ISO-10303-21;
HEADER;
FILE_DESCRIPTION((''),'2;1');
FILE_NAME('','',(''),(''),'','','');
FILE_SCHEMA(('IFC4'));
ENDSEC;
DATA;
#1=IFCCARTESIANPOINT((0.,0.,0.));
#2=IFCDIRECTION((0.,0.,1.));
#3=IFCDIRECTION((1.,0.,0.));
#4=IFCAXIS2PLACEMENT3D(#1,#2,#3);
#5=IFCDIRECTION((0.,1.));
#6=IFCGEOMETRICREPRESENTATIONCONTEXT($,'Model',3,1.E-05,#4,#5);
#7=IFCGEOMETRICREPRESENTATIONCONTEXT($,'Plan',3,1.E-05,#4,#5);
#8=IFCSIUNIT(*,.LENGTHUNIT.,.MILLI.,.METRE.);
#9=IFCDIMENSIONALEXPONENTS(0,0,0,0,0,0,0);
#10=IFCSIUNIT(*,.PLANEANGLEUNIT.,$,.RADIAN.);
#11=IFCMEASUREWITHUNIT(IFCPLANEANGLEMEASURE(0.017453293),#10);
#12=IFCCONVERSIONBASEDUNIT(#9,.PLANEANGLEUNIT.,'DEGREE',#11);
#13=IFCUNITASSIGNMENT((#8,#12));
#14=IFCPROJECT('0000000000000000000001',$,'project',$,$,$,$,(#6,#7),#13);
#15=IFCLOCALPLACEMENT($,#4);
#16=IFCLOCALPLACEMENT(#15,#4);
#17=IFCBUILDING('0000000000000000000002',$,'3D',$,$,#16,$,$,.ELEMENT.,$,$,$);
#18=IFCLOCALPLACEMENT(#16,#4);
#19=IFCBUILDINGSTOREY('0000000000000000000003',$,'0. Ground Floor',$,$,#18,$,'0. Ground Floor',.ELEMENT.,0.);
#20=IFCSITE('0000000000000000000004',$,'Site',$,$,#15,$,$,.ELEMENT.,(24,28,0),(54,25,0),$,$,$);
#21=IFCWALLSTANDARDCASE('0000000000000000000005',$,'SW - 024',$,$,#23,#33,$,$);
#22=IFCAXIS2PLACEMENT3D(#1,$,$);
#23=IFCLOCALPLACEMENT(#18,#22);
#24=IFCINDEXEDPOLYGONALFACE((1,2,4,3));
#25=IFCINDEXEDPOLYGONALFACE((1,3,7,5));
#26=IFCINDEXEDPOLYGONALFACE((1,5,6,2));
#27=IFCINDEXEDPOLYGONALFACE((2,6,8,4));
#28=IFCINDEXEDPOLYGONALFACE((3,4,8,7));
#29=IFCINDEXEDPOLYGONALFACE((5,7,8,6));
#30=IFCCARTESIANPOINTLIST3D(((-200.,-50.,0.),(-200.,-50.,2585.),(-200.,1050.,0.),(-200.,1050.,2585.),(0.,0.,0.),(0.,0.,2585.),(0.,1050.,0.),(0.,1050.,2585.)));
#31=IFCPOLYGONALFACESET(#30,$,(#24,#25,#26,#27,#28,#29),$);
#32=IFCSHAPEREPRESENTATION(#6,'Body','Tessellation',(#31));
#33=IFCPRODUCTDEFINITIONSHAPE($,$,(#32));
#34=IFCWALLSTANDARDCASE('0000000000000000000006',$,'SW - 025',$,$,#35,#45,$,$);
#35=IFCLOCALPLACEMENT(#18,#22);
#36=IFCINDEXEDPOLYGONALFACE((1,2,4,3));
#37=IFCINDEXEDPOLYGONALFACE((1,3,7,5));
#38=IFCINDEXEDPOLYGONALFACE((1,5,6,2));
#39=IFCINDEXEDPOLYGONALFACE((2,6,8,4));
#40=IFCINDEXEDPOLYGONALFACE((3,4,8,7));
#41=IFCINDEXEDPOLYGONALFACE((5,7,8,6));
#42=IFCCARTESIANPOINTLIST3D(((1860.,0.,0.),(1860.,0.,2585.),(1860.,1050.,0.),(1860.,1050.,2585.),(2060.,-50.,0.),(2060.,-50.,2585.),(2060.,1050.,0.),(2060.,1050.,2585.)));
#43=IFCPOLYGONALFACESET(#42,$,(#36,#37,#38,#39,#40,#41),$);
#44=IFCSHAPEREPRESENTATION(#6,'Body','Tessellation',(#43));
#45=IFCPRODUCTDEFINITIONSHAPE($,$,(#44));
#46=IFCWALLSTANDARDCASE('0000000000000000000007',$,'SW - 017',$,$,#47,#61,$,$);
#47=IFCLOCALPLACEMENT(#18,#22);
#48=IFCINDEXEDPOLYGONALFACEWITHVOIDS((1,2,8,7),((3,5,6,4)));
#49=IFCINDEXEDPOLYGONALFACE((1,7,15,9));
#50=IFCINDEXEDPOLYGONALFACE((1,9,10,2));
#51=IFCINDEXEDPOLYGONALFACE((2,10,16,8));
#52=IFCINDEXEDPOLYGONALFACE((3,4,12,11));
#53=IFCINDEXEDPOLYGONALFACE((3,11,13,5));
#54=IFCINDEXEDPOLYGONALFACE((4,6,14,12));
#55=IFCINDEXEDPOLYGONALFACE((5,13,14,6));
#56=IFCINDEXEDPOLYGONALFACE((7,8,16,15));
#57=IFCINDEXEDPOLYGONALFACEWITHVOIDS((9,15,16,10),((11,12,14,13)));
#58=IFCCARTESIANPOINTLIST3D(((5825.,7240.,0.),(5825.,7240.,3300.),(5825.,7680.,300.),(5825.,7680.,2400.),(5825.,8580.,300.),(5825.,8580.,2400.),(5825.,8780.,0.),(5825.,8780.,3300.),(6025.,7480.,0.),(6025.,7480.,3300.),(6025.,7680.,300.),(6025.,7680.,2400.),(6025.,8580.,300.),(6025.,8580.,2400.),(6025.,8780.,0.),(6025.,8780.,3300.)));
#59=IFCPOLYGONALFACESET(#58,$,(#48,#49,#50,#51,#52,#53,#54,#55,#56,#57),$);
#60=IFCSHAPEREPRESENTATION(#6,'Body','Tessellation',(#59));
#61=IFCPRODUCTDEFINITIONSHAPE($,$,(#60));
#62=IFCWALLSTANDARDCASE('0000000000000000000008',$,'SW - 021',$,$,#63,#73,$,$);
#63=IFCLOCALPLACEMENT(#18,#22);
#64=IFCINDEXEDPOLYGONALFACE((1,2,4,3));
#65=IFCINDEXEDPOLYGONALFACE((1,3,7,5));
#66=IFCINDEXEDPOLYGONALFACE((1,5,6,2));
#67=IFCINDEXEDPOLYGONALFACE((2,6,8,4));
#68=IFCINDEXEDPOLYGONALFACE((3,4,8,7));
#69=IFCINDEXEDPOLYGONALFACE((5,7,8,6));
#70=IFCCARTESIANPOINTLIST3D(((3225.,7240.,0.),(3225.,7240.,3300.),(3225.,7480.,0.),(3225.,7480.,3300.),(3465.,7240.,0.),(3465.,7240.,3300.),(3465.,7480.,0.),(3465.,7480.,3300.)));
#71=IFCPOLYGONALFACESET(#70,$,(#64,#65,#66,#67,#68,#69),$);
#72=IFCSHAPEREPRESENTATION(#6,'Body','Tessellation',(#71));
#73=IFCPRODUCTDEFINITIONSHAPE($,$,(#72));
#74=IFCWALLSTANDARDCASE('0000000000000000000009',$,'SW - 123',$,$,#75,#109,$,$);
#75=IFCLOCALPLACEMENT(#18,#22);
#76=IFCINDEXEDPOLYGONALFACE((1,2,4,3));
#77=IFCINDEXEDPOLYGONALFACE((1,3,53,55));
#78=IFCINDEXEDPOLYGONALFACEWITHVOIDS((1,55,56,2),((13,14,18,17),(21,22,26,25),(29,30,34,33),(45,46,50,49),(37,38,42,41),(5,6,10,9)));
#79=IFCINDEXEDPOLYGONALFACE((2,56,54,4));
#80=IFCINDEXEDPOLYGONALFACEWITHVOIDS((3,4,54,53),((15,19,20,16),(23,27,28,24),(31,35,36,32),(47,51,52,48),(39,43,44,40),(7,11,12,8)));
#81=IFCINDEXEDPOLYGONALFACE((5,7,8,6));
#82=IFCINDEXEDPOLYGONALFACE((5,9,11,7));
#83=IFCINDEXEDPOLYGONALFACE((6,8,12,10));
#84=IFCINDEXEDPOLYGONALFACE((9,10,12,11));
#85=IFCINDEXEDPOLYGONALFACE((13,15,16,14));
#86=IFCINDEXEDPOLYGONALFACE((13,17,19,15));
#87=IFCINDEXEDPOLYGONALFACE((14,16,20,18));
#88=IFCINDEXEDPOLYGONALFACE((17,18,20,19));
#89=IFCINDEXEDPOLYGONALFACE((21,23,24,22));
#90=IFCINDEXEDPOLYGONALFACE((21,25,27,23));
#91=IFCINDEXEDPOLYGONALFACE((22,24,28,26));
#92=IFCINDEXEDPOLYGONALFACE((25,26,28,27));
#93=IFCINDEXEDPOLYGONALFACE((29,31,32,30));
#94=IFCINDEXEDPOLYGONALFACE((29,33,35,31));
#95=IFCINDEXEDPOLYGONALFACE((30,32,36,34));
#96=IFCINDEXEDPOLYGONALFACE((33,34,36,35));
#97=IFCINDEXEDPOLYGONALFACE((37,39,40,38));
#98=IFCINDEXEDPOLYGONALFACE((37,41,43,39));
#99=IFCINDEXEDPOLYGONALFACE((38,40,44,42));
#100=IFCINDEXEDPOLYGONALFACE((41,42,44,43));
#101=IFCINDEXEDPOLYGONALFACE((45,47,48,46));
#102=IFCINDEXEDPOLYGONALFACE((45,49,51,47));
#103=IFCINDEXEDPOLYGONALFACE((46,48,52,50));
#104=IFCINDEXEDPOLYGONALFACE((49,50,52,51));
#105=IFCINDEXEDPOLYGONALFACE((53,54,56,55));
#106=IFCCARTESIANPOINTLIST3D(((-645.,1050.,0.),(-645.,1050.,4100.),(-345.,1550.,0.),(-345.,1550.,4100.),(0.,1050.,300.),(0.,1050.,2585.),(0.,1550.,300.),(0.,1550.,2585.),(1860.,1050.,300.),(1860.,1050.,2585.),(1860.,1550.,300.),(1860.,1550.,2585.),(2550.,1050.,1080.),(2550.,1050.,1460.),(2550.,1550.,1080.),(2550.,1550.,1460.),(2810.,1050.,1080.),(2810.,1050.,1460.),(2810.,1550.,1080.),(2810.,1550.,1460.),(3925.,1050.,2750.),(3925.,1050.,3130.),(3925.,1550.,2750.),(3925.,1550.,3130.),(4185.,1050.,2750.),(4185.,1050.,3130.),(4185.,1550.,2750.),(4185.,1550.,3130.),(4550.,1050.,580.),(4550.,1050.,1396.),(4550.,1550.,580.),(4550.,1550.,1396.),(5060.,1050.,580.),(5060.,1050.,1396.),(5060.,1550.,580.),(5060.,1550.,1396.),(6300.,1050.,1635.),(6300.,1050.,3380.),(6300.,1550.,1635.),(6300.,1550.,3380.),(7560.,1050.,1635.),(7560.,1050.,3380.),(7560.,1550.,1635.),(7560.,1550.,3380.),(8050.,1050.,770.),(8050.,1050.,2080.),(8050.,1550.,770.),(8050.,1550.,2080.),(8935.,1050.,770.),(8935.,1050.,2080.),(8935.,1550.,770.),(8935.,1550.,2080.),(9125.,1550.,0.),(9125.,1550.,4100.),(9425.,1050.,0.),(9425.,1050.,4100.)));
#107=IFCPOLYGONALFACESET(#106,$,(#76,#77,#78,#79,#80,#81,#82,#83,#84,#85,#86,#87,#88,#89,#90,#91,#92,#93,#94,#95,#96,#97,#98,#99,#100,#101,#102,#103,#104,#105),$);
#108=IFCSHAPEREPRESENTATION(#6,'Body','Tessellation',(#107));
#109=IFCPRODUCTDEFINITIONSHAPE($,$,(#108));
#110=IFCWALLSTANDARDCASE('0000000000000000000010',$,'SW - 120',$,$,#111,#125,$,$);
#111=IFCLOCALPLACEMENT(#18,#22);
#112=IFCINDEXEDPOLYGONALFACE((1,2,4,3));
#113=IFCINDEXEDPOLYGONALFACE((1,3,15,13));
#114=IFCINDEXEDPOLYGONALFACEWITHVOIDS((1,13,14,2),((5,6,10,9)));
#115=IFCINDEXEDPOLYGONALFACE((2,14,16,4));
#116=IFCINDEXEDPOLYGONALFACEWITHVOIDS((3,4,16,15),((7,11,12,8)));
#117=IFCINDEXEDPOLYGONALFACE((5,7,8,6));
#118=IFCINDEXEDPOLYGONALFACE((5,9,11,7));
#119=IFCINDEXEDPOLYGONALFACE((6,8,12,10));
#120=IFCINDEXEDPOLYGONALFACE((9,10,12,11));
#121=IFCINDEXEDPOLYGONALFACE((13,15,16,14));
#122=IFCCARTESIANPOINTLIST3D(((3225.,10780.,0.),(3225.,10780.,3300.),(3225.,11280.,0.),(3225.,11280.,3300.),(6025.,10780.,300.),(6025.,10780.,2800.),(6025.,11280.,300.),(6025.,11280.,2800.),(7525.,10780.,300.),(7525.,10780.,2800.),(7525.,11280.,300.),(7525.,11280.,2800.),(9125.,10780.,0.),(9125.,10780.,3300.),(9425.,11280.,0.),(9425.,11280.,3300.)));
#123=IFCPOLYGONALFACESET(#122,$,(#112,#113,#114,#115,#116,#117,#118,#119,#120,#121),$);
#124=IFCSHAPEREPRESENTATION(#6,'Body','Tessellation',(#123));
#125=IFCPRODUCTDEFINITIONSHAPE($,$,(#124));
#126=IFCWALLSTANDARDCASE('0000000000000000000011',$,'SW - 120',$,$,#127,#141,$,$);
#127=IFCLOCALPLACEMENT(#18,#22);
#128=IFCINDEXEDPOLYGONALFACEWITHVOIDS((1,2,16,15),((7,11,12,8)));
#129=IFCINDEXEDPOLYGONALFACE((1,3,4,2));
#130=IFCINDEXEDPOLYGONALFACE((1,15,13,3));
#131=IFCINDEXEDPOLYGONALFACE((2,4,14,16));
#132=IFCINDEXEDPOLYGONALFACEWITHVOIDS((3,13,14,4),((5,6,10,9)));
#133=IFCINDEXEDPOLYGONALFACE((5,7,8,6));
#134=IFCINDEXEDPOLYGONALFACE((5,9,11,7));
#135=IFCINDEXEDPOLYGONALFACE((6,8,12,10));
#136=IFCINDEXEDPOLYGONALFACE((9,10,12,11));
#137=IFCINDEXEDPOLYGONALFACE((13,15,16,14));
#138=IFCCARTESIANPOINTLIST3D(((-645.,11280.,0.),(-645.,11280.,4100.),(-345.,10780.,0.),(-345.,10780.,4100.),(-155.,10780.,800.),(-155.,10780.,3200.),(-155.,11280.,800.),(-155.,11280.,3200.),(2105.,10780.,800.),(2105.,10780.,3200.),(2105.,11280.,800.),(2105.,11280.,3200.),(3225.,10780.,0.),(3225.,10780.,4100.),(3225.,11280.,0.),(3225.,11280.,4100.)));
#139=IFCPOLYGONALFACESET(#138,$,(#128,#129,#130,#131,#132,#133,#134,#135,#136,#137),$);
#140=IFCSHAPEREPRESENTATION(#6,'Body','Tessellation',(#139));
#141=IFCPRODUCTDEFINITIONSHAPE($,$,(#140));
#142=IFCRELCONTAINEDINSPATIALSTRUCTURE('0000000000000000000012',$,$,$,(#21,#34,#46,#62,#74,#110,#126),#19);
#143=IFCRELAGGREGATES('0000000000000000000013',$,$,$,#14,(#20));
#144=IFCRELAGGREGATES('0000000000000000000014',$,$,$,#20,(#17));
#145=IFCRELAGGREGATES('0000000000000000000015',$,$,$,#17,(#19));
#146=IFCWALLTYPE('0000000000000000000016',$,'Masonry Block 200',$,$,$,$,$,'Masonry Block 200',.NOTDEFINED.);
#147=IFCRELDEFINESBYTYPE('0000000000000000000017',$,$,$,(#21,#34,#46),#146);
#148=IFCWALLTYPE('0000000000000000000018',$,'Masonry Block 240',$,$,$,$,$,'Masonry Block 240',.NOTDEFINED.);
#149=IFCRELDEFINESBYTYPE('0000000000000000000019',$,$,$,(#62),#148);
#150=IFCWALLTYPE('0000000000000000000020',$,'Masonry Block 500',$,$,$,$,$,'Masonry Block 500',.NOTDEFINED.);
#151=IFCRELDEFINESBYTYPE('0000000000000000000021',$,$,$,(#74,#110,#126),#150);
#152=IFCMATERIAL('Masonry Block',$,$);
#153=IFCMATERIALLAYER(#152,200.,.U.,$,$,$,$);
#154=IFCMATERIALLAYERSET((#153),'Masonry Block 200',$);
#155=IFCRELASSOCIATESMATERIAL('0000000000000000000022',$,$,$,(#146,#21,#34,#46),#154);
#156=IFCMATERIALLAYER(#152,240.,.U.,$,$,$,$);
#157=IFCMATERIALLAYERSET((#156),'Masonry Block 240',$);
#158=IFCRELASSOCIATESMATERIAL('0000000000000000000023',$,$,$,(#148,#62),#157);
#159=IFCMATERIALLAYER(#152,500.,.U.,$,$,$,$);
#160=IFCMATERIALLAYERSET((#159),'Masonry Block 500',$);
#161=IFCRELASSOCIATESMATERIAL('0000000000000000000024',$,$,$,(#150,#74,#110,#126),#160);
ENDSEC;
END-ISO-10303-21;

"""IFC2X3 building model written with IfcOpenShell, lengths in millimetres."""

from ifc_helpers import new_model, entity, si_unit, converted_unit, direction, frame, frame_2d, origin_with_axes, place, context, project, spatial, polyline, rectangle, outline, extrude, material, layer, layer_set, layer_usage, type_object, element, save


model = new_model("IFC2X3")

# Units and contexts
model_context = context("Model", 3, precision=1e-05, world=origin_with_axes(), true_north=direction((0.0, 1.0)))
plan_context = context("Plan", 3, precision=1e-05, world=origin_with_axes(), true_north=direction((0.0, 1.0)))
ifc_project = project(units=[si_unit("LENGTHUNIT", "METRE", prefix="MILLI"), converted_unit("PLANEANGLEUNIT", "DEGREE", entity("IfcPlaneAngleMeasure", 0.017453293), si_unit("PLANEANGLEUNIT", "RADIAN"), dimensions=[0, 0, 0, 0, 0, 0, 0])], contexts=[model_context, plan_context])

# Site, building, storey
site_placement = place(None, origin_with_axes())
site = spatial("IfcSite", under=ifc_project, at=site_placement, Name="Site", CompositionType="ELEMENT", RefLatitude=(24, 28, 0), RefLongitude=(54, 25, 0))
building_placement = place(site_placement, origin_with_axes())
building = spatial("IfcBuilding", under=site, at=building_placement, Name="3D", CompositionType="ELEMENT")
storey_placement = place(building_placement, origin_with_axes())
storey = spatial("IfcBuildingStorey", under=building, at=storey_placement, Name="0. Ground Floor", LongName="0. Ground Floor", CompositionType="ELEMENT", Elevation=0.0)

# Shared definitions
ifc_material_1 = material(Name="Masonry Block")
ifc_layer_1 = layer(ifc_material_1, 200.0, ventilated="UNKNOWN")
ifc_layer_set_1 = layer_set([ifc_layer_1], Name="Masonry Block 200")

# Wall
ifc_layer_usage_1 = layer_usage(ifc_layer_set_1, "AXIS2", "NEGATIVE", 0.0)
wall_type_1 = type_object("IfcWallType", Name="Masonry Block 200", ElementType="Masonry Block 200", PredefinedType="NOTDEFINED", material=ifc_layer_set_1)
wall_1_placement = place(storey_placement, frame((0.0, 1050.0, 0.0), z_axis=(0.0, 0.0, 1.0), x_axis=(0.0, -1.0, 0.0)))
element("IfcWallStandardCase", 1, at=wall_1_placement, inside=storey, type_object=wall_type_1, material=ifc_layer_usage_1, Name="SW - 024", context=model_context, shape_type="SweptSolid", body=[
    extrude(outline(polyline([(0.0, -200.0), (1100.0, -200.0), (1050.0, 0.0), (0.0, 0.0), (0.0, -200.0)])), origin_with_axes(), (0.0, 0.0, 1.0), 2585.0),
])

# Wall
ifc_layer_usage_2 = layer_usage(ifc_layer_set_1, "AXIS2", "POSITIVE", 0.0)
wall_2_placement = place(storey_placement, frame((1860.0, 1050.0, 0.0), z_axis=(0.0, 0.0, 1.0), x_axis=(0.0, -1.0, 0.0)))
element("IfcWallStandardCase", 2, at=wall_2_placement, inside=storey, type_object=wall_type_1, material=ifc_layer_usage_2, Name="SW - 025", context=model_context, shape_type="SweptSolid", body=[
    extrude(outline(polyline([(0.0, 0.0), (1050.0, 0.0), (1100.0, 200.0), (0.0, 200.0), (0.0, 0.0)])), origin_with_axes(), (0.0, 0.0, 1.0), 2585.0),
])

# Wall, opening
ifc_layer_usage_3 = layer_usage(ifc_layer_set_1, "AXIS2", "NEGATIVE", 0.0)
wall_3_placement = place(storey_placement, frame((6025.0, 8780.0, 0.0), z_axis=(0.0, 0.0, 1.0), x_axis=(0.0, -1.0, 0.0)))
wall_3 = element("IfcWallStandardCase", 3, at=wall_3_placement, inside=storey, type_object=wall_type_1, material=ifc_layer_usage_3, Name="SW - 017", context=model_context, shape_type="SweptSolid", body=[
    extrude(outline(polyline([(0.0, -200.0), (1540.0, -200.0), (1300.0, 0.0), (0.0, 0.0), (0.0, -200.0)])), origin_with_axes(), (0.0, 0.0, 1.0), 3300.0),
])
opening_1_placement = place(wall_3_placement, frame((650.0, -200.0, 300.0), z_axis=(0.0, 0.0, 1.0), x_axis=(1.0, 0.0, 0.0)))
element("IfcOpeningElement", 4, at=opening_1_placement, cuts=wall_3, ObjectType="Opening", context=model_context, shape_type="SweptSolid", body=[
    extrude(rectangle(XDim=900.0, YDim=2100.0, at=frame_2d((0.0, 1050.0), x_axis=(-1.0, 0.0))), frame((0.0, 0.0, 0.0), z_axis=(0.0, 1.0, 0.0), x_axis=(-1.0, 0.0, 0.0)), (0.0, 0.0, 1.0), 200.0),
])

# Wall
ifc_layer_2 = layer(ifc_material_1, 240.0, ventilated="UNKNOWN")
ifc_layer_set_2 = layer_set([ifc_layer_2], Name="Masonry Block 240")
wall_type_2 = type_object("IfcWallType", Name="Masonry Block 240", ElementType="Masonry Block 240", PredefinedType="NOTDEFINED", material=ifc_layer_set_2)
ifc_layer_usage_4 = layer_usage(ifc_layer_set_2, "AXIS2", "NEGATIVE", 0.0)
wall_4_placement = place(storey_placement, frame((3225.0, 7240.0, 0.0), z_axis=(0.0, 0.0, 1.0), x_axis=(0.0, 1.0, 0.0)))
element("IfcWallStandardCase", 5, at=wall_4_placement, inside=storey, type_object=wall_type_2, material=ifc_layer_usage_4, Name="SW - 021", context=model_context, shape_type="SweptSolid", body=[
    extrude(outline(polyline([(0.0, -240.0), (240.0, -240.0), (240.0, 0.0), (0.0, 0.0), (0.0, -240.0)])), origin_with_axes(), (0.0, 0.0, 1.0), 3300.0),
])

# Wall, openings
ifc_layer_3 = layer(ifc_material_1, 500.0, ventilated="UNKNOWN")
ifc_layer_set_3 = layer_set([ifc_layer_3], Name="Masonry Block 500")
ifc_layer_usage_5 = layer_usage(ifc_layer_set_3, "AXIS2", "POSITIVE", 0.0)
wall_type_3 = type_object("IfcWallType", Name="Masonry Block 500", ElementType="Masonry Block 500", PredefinedType="NOTDEFINED", material=ifc_layer_set_3)
wall_5_placement = place(storey_placement, frame((-645.0, 1050.0, 0.0), z_axis=(0.0, 0.0, 1.0), x_axis=(1.0, 0.0, 0.0)))
wall_5 = element("IfcWallStandardCase", 6, at=wall_5_placement, inside=storey, type_object=wall_type_3, material=ifc_layer_usage_5, Name="SW - 123", context=model_context, shape_type="SweptSolid", body=[
    extrude(outline(polyline([(0.0, 0.0), (10070.0, 0.0), (9770.0, 500.0), (300.0, 500.0), (0.0, 0.0)])), origin_with_axes(), (0.0, 0.0, 1.0), 4100.0),
])
opening_2_placement = place(wall_5_placement, frame((7575.0, 0.0, 1635.0), z_axis=(0.0, 0.0, 1.0), x_axis=(1.0, 0.0, 0.0)))
element("IfcOpeningElement", 7, at=opening_2_placement, cuts=wall_5, ObjectType="Opening", context=model_context, shape_type="SweptSolid", body=[
    extrude(rectangle(XDim=1260.0, YDim=1745.0, at=frame_2d((0.0, 872.5), x_axis=(1.0, 0.0))), frame((0.0, 0.0, 0.0), z_axis=(0.0, 1.0, 0.0), x_axis=(-1.0, 0.0, 0.0)), (0.0, 0.0, 1.0), 500.0),
])
opening_3_placement = place(wall_5_placement, frame((1575.0, 0.0, 300.0), z_axis=(0.0, 0.0, 1.0), x_axis=(1.0, 0.0, 0.0)))
element("IfcOpeningElement", 8, at=opening_3_placement, cuts=wall_5, ObjectType="Opening", context=model_context, shape_type="SweptSolid", body=[
    extrude(rectangle(XDim=1860.0, YDim=2285.0, at=frame_2d((0.0, 1142.5), x_axis=(1.0, 0.0))), frame((0.0, 0.0, 0.0), z_axis=(0.0, 1.0, 0.0), x_axis=(-1.0, 0.0, 0.0)), (0.0, 0.0, 1.0), 500.0),
])
opening_4_placement = place(wall_5_placement, frame((9137.5, 0.0, 770.0), z_axis=(0.0, 0.0, 1.0), x_axis=(1.0, 0.0, 0.0)))
element("IfcOpeningElement", 9, at=opening_4_placement, cuts=wall_5, ObjectType="Opening", context=model_context, shape_type="SweptSolid", body=[
    extrude(rectangle(XDim=885.0, YDim=1310.0, at=frame_2d((0.0, 655.0), x_axis=(-1.0, 0.0))), frame((0.0, 0.0, 0.0), z_axis=(0.0, 1.0, 0.0), x_axis=(-1.0, 0.0, 0.0)), (0.0, 0.0, 1.0), 500.0),
])
opening_5_placement = place(wall_5_placement, frame((3325.0, 0.0, 1080.0), z_axis=(0.0, 0.0, 1.0), x_axis=(1.0, 0.0, 0.0)))
element("IfcOpeningElement", 10, at=opening_5_placement, cuts=wall_5, ObjectType="Opening", context=model_context, shape_type="SweptSolid", body=[
    extrude(rectangle(XDim=260.0, YDim=380.0, at=frame_2d((0.0, 190.0), x_axis=(-1.0, 0.0))), frame((0.0, 0.0, 0.0), z_axis=(0.0, 1.0, 0.0), x_axis=(-1.0, 0.0, 0.0)), (0.0, 0.0, 1.0), 500.0),
])
opening_6_placement = place(wall_5_placement, frame((4700.0, 0.0, 2750.0), z_axis=(0.0, 0.0, 1.0), x_axis=(1.0, 0.0, 0.0)))
element("IfcOpeningElement", 11, at=opening_6_placement, cuts=wall_5, ObjectType="Opening", context=model_context, shape_type="SweptSolid", body=[
    extrude(rectangle(XDim=260.0, YDim=380.0, at=frame_2d((0.0, 190.0), x_axis=(1.0, 0.0))), frame((0.0, 0.0, 0.0), z_axis=(0.0, 1.0, 0.0), x_axis=(-1.0, 0.0, 0.0)), (0.0, 0.0, 1.0), 500.0),
])
opening_7_placement = place(wall_5_placement, frame((5450.0, 0.0, 580.0), z_axis=(0.0, 0.0, 1.0), x_axis=(1.0, 0.0, 0.0)))
element("IfcOpeningElement", 12, at=opening_7_placement, cuts=wall_5, ObjectType="Opening", context=model_context, shape_type="SweptSolid", body=[
    extrude(rectangle(XDim=510.0, YDim=816.0, at=frame_2d((0.0, 408.0), x_axis=(-1.0, 0.0))), frame((0.0, 0.0, 0.0), z_axis=(0.0, 1.0, 0.0), x_axis=(-1.0, 0.0, 0.0)), (0.0, 0.0, 1.0), 500.0),
])

# Walls, openings
ifc_layer_usage_6 = layer_usage(ifc_layer_set_3, "AXIS2", "NEGATIVE", 0.0)
wall_6_placement = place(storey_placement, frame((3225.0, 11280.0, 0.0), z_axis=(0.0, 0.0, 1.0), x_axis=(1.0, 0.0, 0.0)))
wall_6 = element("IfcWallStandardCase", 13, at=wall_6_placement, inside=storey, type_object=wall_type_3, material=ifc_layer_usage_6, Name="SW - 120", context=model_context, shape_type="SweptSolid", body=[
    extrude(outline(polyline([(0.0, -500.0), (5900.0, -500.0), (6200.0, 0.0), (0.0, 0.0), (0.0, -500.0)])), origin_with_axes(), (0.0, 0.0, 1.0), 3300.0),
])
opening_8_placement = place(wall_6_placement, frame((3550.0, -500.0, 300.0), z_axis=(0.0, 0.0, 1.0), x_axis=(1.0, 0.0, 0.0)))
element("IfcOpeningElement", 14, at=opening_8_placement, cuts=wall_6, ObjectType="Opening", context=model_context, shape_type="SweptSolid", body=[
    extrude(rectangle(XDim=1500.0, YDim=2500.0, at=frame_2d((0.0, 1250.0), x_axis=(1.0, 0.0))), frame((0.0, 0.0, 0.0), z_axis=(0.0, 1.0, 0.0), x_axis=(-1.0, 0.0, 0.0)), (0.0, 0.0, 1.0), 500.0),
])
ifc_layer_usage_7 = layer_usage(ifc_layer_set_3, "AXIS2", "NEGATIVE", 0.0)
wall_7_placement = place(storey_placement, frame((-645.0, 11280.0, 0.0), z_axis=(0.0, 0.0, 1.0), x_axis=(1.0, 0.0, 0.0)))
wall_7 = element("IfcWallStandardCase", 15, at=wall_7_placement, inside=storey, type_object=wall_type_3, material=ifc_layer_usage_7, Name="SW - 120", context=model_context, shape_type="SweptSolid", body=[
    extrude(outline(polyline([(300.0, -500.0), (3870.0, -500.0), (3870.0, 0.0), (0.0, 0.0), (300.0, -500.0)])), origin_with_axes(), (0.0, 0.0, 1.0), 4100.0),
])
opening_9_placement = place(wall_7_placement, frame((1620.0, -500.0, 800.0), z_axis=(0.0, 0.0, 1.0), x_axis=(1.0, 0.0, 0.0)))
element("IfcOpeningElement", 16, at=opening_9_placement, cuts=wall_7, ObjectType="Opening", context=model_context, shape_type="SweptSolid", body=[
    extrude(rectangle(XDim=2260.0, YDim=2400.0, at=frame_2d((0.0, 1200.0), x_axis=(1.0, 0.0))), frame((0.0, 0.0, 0.0), z_axis=(0.0, 1.0, 0.0), x_axis=(-1.0, 0.0, 0.0)), (0.0, 0.0, 1.0), 500.0),
])

save(model, "model.ifc")
